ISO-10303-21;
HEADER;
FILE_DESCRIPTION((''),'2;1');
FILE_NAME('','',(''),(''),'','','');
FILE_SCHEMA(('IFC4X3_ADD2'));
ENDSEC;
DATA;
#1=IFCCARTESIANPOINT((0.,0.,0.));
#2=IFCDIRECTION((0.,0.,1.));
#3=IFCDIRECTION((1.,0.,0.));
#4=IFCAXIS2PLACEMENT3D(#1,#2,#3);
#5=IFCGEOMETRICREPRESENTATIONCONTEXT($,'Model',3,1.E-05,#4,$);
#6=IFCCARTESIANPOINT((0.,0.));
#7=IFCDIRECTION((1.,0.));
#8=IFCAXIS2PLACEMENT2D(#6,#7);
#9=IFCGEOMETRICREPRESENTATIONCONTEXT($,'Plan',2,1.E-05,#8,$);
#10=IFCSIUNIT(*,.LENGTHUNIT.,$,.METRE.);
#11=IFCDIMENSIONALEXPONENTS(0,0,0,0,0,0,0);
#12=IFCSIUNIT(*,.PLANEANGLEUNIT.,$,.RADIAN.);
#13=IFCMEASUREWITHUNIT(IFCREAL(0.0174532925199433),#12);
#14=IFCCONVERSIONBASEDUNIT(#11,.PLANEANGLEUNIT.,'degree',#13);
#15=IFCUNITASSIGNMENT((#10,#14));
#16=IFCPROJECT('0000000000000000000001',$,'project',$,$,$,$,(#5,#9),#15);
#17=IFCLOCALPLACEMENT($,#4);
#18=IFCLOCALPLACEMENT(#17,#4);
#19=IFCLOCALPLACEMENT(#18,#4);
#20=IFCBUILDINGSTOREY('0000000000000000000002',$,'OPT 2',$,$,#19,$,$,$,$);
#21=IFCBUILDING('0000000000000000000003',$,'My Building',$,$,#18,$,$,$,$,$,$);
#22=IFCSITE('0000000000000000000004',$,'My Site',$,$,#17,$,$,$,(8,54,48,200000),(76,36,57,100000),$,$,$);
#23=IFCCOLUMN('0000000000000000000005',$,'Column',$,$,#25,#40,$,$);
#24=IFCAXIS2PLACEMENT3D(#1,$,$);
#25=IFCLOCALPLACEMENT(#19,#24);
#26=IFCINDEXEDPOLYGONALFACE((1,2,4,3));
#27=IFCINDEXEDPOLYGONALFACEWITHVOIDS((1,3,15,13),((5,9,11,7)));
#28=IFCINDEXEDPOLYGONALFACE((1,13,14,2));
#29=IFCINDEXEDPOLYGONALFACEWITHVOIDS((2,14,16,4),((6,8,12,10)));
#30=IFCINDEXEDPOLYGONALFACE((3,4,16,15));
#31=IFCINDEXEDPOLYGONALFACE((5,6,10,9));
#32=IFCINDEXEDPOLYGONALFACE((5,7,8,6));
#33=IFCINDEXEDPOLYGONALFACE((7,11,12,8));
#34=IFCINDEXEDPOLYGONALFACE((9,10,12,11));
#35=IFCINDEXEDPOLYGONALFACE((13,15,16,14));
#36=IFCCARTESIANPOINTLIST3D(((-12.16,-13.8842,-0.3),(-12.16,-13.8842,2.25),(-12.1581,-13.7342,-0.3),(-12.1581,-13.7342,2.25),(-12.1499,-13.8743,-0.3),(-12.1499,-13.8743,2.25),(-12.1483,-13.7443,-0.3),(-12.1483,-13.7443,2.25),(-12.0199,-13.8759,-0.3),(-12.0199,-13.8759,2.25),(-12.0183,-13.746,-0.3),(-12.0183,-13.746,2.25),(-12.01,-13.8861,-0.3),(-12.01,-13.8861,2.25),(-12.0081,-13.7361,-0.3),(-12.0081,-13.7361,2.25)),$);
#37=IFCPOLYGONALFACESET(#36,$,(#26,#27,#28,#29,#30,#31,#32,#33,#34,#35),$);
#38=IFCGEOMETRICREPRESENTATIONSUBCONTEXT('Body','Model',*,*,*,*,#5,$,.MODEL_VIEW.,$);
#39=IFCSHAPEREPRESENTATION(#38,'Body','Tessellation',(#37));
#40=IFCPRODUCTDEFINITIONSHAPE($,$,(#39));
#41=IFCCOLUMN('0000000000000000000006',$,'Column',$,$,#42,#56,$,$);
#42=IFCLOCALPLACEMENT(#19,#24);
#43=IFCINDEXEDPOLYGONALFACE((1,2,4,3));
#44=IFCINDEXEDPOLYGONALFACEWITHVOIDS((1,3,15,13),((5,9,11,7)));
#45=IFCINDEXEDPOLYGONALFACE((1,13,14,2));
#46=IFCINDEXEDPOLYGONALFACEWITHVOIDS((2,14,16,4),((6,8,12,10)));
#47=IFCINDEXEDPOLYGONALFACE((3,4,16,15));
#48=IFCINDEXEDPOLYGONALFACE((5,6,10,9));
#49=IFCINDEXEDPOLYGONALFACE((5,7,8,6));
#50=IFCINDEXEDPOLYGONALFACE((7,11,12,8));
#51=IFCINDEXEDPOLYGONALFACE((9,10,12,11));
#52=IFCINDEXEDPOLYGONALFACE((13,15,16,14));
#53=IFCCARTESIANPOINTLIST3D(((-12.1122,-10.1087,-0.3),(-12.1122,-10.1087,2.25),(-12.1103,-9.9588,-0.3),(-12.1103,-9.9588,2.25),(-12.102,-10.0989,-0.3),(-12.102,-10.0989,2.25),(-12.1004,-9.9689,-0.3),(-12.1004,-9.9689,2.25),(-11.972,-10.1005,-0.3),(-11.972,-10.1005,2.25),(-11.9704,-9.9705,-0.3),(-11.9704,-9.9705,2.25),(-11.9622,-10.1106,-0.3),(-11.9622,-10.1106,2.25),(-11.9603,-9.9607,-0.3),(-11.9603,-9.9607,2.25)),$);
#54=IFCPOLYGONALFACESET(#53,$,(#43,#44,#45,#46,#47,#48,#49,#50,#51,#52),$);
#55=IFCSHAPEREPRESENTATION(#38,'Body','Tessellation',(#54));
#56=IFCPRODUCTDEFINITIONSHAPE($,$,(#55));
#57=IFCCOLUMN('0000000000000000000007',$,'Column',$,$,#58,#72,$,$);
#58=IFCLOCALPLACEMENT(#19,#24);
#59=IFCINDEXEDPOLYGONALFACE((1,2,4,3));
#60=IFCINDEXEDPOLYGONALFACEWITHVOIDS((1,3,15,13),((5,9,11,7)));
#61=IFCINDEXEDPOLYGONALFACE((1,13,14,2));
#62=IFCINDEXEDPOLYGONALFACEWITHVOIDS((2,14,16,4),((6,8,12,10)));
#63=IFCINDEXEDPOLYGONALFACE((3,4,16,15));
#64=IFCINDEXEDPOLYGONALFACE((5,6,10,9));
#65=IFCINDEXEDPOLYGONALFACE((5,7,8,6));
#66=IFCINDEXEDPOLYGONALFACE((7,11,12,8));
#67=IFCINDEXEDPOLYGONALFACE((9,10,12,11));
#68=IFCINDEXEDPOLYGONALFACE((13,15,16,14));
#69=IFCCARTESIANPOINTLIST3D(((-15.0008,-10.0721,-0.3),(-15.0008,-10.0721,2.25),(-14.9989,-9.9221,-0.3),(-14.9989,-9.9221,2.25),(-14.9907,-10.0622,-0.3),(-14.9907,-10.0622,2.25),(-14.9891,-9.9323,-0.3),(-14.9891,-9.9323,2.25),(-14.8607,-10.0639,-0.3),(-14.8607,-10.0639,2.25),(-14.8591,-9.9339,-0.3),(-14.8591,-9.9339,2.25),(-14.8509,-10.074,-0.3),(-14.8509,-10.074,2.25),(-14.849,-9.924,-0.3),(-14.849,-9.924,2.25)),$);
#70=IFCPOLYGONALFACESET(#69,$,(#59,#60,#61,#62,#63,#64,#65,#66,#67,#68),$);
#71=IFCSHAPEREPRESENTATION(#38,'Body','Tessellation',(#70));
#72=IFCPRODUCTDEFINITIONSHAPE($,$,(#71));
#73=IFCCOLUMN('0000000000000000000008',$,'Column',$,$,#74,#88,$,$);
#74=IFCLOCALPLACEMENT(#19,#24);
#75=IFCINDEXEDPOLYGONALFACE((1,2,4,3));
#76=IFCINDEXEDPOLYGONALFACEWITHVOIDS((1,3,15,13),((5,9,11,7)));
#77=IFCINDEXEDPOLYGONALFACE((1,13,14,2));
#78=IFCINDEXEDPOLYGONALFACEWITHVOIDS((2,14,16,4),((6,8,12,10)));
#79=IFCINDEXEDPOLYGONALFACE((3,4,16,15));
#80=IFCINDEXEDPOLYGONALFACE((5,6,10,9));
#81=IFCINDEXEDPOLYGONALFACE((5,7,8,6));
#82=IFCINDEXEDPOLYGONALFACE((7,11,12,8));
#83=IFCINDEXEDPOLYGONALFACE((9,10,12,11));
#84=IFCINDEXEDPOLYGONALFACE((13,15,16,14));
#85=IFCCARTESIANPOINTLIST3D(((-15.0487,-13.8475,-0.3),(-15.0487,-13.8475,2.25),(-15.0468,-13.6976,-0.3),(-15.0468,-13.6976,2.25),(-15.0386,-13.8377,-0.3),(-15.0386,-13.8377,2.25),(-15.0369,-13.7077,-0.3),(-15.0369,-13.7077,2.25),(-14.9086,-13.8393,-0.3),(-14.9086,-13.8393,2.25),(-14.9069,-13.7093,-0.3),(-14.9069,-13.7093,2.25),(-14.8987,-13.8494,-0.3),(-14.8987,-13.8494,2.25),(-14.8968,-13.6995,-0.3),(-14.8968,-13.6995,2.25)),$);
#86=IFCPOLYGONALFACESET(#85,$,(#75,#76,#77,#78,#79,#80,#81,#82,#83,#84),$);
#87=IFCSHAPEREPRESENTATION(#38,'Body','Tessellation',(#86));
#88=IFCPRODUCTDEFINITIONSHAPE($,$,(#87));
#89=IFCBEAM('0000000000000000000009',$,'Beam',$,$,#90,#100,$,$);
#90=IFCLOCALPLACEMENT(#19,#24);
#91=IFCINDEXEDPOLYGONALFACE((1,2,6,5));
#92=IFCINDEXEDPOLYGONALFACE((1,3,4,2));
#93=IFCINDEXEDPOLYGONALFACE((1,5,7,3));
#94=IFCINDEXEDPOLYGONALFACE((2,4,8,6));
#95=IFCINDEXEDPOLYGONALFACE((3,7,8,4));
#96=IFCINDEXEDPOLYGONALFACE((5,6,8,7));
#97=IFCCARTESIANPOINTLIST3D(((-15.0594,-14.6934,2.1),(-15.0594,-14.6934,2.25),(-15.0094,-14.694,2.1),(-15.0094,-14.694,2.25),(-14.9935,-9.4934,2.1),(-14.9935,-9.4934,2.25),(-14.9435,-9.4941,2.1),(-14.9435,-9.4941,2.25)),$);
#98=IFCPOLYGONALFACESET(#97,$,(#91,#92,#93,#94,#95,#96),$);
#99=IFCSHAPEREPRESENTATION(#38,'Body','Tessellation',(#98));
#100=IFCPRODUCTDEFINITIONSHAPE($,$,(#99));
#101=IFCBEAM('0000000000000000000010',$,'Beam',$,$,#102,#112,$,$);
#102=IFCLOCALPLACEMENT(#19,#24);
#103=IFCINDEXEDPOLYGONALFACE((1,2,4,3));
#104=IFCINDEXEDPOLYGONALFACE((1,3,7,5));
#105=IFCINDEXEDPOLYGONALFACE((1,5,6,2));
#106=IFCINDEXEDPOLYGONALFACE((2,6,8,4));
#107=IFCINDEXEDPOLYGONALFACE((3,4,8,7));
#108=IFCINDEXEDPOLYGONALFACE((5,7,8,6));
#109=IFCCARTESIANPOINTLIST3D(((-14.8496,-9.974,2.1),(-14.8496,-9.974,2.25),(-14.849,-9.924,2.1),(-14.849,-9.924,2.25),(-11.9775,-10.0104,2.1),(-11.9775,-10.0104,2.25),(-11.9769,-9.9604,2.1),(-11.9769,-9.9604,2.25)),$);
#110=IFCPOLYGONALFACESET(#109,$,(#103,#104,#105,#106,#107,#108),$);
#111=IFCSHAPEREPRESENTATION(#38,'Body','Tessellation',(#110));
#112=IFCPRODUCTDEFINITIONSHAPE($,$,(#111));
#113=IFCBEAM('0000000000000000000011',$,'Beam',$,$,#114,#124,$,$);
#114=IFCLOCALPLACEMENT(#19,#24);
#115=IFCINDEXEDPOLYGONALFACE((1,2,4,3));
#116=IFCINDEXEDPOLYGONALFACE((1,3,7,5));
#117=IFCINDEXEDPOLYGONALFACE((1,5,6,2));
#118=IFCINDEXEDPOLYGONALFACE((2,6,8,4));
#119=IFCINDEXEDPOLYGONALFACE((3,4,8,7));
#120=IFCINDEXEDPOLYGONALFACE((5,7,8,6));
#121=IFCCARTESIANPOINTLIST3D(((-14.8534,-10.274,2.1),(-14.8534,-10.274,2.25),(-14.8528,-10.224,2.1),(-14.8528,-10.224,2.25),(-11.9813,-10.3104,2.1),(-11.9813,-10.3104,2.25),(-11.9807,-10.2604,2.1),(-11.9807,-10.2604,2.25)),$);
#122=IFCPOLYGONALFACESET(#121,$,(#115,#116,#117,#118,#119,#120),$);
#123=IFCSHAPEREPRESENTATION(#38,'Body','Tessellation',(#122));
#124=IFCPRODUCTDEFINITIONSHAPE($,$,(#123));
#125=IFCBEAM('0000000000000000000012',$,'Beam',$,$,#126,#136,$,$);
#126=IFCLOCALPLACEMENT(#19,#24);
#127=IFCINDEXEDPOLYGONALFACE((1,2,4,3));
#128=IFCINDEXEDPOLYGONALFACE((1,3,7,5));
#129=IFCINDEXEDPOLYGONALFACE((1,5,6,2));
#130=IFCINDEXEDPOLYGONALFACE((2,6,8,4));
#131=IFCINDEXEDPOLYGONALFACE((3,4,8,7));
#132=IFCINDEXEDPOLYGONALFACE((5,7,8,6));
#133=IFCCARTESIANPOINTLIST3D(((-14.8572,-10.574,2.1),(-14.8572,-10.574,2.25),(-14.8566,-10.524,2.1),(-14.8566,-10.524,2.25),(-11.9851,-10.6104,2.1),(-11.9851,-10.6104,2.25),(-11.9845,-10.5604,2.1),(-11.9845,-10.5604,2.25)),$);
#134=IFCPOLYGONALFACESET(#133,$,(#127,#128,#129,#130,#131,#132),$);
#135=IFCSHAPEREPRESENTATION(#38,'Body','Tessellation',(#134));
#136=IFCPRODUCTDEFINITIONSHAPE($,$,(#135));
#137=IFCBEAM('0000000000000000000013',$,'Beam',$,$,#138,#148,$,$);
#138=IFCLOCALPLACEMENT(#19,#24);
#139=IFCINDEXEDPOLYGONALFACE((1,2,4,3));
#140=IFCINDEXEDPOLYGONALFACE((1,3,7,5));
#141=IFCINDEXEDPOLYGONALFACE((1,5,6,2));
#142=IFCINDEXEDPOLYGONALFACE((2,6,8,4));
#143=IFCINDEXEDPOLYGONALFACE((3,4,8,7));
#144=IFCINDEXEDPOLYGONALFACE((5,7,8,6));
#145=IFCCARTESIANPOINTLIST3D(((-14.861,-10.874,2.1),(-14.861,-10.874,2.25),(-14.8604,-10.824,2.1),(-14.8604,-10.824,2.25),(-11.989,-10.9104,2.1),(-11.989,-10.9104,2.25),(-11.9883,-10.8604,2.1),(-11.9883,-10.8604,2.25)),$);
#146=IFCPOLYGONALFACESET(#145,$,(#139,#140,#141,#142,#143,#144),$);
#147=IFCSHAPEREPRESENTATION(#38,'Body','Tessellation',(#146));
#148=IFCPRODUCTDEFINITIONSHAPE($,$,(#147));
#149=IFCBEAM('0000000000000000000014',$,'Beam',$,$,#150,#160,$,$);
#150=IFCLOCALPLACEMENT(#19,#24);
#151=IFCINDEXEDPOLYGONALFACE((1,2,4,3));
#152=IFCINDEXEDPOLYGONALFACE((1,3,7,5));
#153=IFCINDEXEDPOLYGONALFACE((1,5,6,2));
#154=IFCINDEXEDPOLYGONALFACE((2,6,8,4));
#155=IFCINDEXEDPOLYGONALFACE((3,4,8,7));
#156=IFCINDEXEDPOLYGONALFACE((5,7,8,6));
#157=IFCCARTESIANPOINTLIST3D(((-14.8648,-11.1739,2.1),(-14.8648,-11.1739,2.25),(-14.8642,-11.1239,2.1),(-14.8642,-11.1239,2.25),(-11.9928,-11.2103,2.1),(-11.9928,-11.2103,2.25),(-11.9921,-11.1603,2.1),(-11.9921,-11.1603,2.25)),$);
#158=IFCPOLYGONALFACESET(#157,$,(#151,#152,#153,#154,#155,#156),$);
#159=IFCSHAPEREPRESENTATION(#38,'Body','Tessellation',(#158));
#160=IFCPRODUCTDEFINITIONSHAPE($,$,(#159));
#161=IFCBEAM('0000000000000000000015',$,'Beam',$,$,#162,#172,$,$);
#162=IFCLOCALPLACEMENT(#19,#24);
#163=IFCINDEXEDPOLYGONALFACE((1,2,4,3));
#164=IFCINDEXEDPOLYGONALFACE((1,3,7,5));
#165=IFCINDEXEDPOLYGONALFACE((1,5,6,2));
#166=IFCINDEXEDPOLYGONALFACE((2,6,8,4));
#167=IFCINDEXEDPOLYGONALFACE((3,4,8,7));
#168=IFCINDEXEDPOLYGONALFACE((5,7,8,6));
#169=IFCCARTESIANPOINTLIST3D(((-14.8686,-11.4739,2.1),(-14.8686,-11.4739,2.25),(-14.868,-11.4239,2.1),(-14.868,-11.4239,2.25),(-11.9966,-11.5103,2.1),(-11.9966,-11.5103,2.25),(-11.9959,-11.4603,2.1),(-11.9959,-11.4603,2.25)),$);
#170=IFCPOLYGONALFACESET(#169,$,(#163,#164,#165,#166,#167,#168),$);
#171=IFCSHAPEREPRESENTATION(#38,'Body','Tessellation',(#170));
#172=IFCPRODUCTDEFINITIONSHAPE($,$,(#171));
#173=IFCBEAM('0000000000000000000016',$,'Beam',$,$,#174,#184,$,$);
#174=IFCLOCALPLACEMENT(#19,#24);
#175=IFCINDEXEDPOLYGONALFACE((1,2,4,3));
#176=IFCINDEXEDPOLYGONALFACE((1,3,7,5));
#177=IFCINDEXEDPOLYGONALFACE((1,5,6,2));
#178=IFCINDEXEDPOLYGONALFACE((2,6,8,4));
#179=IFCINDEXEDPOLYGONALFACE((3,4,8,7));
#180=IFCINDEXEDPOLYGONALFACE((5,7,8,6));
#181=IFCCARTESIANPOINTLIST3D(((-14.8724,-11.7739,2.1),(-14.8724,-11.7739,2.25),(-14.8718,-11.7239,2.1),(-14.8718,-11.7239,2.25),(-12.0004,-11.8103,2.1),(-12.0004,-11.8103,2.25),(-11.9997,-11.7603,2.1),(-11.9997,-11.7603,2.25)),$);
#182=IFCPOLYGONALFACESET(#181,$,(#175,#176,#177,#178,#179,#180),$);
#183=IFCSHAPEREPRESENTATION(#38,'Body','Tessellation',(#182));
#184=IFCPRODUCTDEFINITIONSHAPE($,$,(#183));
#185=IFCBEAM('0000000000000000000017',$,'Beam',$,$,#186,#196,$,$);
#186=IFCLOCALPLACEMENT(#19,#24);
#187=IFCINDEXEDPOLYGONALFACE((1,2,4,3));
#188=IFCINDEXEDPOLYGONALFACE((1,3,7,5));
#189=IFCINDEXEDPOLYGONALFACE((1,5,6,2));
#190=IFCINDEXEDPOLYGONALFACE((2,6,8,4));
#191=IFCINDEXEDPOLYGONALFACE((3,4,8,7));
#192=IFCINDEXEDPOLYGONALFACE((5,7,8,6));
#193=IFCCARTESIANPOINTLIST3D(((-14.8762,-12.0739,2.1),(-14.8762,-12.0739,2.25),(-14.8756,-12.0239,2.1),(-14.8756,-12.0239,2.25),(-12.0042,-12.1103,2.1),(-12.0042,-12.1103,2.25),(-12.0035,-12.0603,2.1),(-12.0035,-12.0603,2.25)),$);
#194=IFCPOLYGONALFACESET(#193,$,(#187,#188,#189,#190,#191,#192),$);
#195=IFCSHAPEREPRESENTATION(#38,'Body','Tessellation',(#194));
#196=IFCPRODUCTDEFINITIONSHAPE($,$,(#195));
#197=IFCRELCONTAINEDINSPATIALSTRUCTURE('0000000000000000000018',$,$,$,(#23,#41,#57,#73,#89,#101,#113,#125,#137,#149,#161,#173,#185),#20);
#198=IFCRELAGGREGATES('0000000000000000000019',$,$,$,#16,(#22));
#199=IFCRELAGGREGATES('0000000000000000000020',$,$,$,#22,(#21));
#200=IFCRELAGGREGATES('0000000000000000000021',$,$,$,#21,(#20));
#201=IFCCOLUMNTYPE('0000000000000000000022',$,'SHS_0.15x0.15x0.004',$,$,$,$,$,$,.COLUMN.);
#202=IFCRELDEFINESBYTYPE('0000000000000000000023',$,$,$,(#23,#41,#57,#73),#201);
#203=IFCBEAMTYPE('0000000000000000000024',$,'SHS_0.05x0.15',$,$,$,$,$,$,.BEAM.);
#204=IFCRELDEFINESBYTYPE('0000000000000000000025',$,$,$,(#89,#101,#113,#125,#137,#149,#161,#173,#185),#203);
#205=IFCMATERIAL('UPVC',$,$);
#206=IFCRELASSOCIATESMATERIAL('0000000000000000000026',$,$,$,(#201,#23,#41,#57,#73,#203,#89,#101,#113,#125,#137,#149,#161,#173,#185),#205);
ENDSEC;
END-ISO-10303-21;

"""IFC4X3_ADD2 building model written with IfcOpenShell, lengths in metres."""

from ifc_helpers import new_model, entity, si_unit, converted_unit, frame, origin_with_axes, origin_2d_with_axis, place, context, subcontext, project, spatial, rectangle, hollow_rectangle, extrude, material, material_profile, profile_set, profile_usage, type_object, element, save


model = new_model("IFC4X3_ADD2")

# Units and contexts
model_context = context("Model", 3, precision=1e-05, world=origin_with_axes())
plan_context = context("Plan", 2, precision=1e-05, world=origin_2d_with_axis())
body_context = subcontext(model_context, "Body", "Model", "MODEL_VIEW")
ifc_project = project(units=[si_unit("LENGTHUNIT", "METRE"), converted_unit("PLANEANGLEUNIT", "degree", entity("IfcReal", 0.0174532925199433), si_unit("PLANEANGLEUNIT", "RADIAN"), dimensions=[0, 0, 0, 0, 0, 0, 0])], contexts=[model_context, plan_context])

# Site, building, storey
site_placement = place(None, origin_with_axes())
site = spatial("IfcSite", under=ifc_project, at=site_placement, Name="My Site", RefLatitude=(8, 54, 48, 200000), RefLongitude=(76, 36, 57, 100000))
building_placement = place(site_placement, origin_with_axes())
building = spatial("IfcBuilding", under=site, at=building_placement, Name="My Building")
storey_placement = place(building_placement, origin_with_axes())
storey = spatial("IfcBuildingStorey", under=building, at=storey_placement, Name="OPT 2")

# Columns
ifc_material_1 = material(Name="UPVC")
ifc_material_profile_1 = material_profile(ifc_material_1, hollow_rectangle(XDim=0.15, YDim=0.15, WallThickness=0.01))
ifc_profile_set_1 = profile_set([ifc_material_profile_1])
ifc_profile_usage_1 = profile_usage(ifc_profile_set_1, cardinal=5)
column_type = type_object("IfcColumnType", Name="SHS_0.15x0.15x0.004", PredefinedType="COLUMN", material=ifc_profile_set_1)
column_1_placement = place(storey_placement, frame((-12.0841, -13.8101, -0.3), z_axis=(0.0, 0.0, 1.0), x_axis=(0.99992, -0.012678, 0.0)))
element("IfcColumn", 1, at=column_1_placement, inside=storey, type_object=column_type, material=ifc_profile_usage_1, Name="Column", context=body_context, shape_type="SweptSolid", body=[
    extrude(hollow_rectangle(XDim=0.15, YDim=0.15, WallThickness=0.01), origin_with_axes(), (0.0, 0.0, 1.0), 2.55),
])
ifc_profile_usage_2 = profile_usage(ifc_profile_set_1, cardinal=5)
column_2_placement = place(storey_placement, frame((-12.0362, -10.0347, -0.3), z_axis=(0.0, 0.0, 1.0), x_axis=(0.99992, -0.012678, 0.0)))
element("IfcColumn", 2, at=column_2_placement, inside=storey, type_object=column_type, material=ifc_profile_usage_2, Name="Column", context=body_context, shape_type="SweptSolid", body=[
    extrude(hollow_rectangle(XDim=0.15, YDim=0.15, WallThickness=0.01), origin_with_axes(), (0.0, 0.0, 1.0), 2.55),
])
ifc_profile_usage_3 = profile_usage(ifc_profile_set_1, cardinal=5)
column_3_placement = place(storey_placement, frame((-14.9249, -9.9981, -0.3), z_axis=(0.0, 0.0, 1.0), x_axis=(0.99992, -0.012678, 0.0)))
element("IfcColumn", 3, at=column_3_placement, inside=storey, type_object=column_type, material=ifc_profile_usage_3, Name="Column", context=body_context, shape_type="SweptSolid", body=[
    extrude(hollow_rectangle(XDim=0.15, YDim=0.15, WallThickness=0.01), origin_with_axes(), (0.0, 0.0, 1.0), 2.55),
])
ifc_profile_usage_4 = profile_usage(ifc_profile_set_1, cardinal=5)
column_4_placement = place(storey_placement, frame((-14.9728, -13.7735, -0.3), z_axis=(0.0, 0.0, 1.0), x_axis=(0.99992, -0.012678, 0.0)))
element("IfcColumn", 4, at=column_4_placement, inside=storey, type_object=column_type, material=ifc_profile_usage_4, Name="Column", context=body_context, shape_type="SweptSolid", body=[
    extrude(hollow_rectangle(XDim=0.15, YDim=0.15, WallThickness=0.01), origin_with_axes(), (0.0, 0.0, 1.0), 2.55),
])

# Beams
ifc_material_profile_2 = material_profile(ifc_material_1, rectangle(XDim=0.05, YDim=0.15))
ifc_profile_set_2 = profile_set([ifc_material_profile_2])
ifc_profile_usage_5 = profile_usage(ifc_profile_set_2, cardinal=5)
beam_type = type_object("IfcBeamType", Name="SHS_0.05x0.15", PredefinedType="BEAM", material=ifc_profile_set_2)
beam_1_placement = place(storey_placement, frame((-15.0344, -14.6937, 2.175), z_axis=(0.012677, 0.99992, 0.0), x_axis=(-0.99992, 0.012677, 0.0)))
element("IfcBeam", 5, at=beam_1_placement, inside=storey, type_object=beam_type, material=ifc_profile_usage_5, Name="Beam", context=body_context, shape_type="SweptSolid", body=[
    extrude(rectangle(XDim=0.05, YDim=0.15), origin_with_axes(), (0.0, 0.0, 1.0), 5.2004),
])
ifc_profile_usage_6 = profile_usage(ifc_profile_set_2, cardinal=5)
beam_2_placement = place(storey_placement, frame((-11.9772, -9.9854, 2.175), z_axis=(-0.99992, 0.012677, 0.000001), x_axis=(-0.012677, -0.99992, 0.0)))
element("IfcBeam", 6, at=beam_2_placement, inside=storey, type_object=beam_type, material=ifc_profile_usage_6, Name="Beam", context=body_context, shape_type="SweptSolid", body=[
    extrude(rectangle(XDim=0.05, YDim=0.15), origin_with_axes(), (0.0, 0.0, 1.0), 2.8723),
])
ifc_profile_usage_7 = profile_usage(ifc_profile_set_2, cardinal=5)
beam_3_placement = place(storey_placement, frame((-11.981, -10.2854, 2.175), z_axis=(-0.99992, 0.012677, 0.000001), x_axis=(-0.012677, -0.99992, 0.0)))
element("IfcBeam", 7, at=beam_3_placement, inside=storey, type_object=beam_type, material=ifc_profile_usage_7, Name="Beam", context=body_context, shape_type="SweptSolid", body=[
    extrude(rectangle(XDim=0.05, YDim=0.15), origin_with_axes(), (0.0, 0.0, 1.0), 2.8723),
])
ifc_profile_usage_8 = profile_usage(ifc_profile_set_2, cardinal=5)
beam_4_placement = place(storey_placement, frame((-11.9848, -10.5854, 2.175), z_axis=(-0.99992, 0.012677, 0.000001), x_axis=(-0.012677, -0.99992, 0.0)))
element("IfcBeam", 8, at=beam_4_placement, inside=storey, type_object=beam_type, material=ifc_profile_usage_8, Name="Beam", context=body_context, shape_type="SweptSolid", body=[
    extrude(rectangle(XDim=0.05, YDim=0.15), origin_with_axes(), (0.0, 0.0, 1.0), 2.8723),
])
ifc_profile_usage_9 = profile_usage(ifc_profile_set_2, cardinal=5)
beam_5_placement = place(storey_placement, frame((-11.9886, -10.8854, 2.175), z_axis=(-0.99992, 0.012677, 0.000001), x_axis=(-0.012677, -0.99992, 0.0)))
element("IfcBeam", 9, at=beam_5_placement, inside=storey, type_object=beam_type, material=ifc_profile_usage_9, Name="Beam", context=body_context, shape_type="SweptSolid", body=[
    extrude(rectangle(XDim=0.05, YDim=0.15), origin_with_axes(), (0.0, 0.0, 1.0), 2.8723),
])
ifc_profile_usage_10 = profile_usage(ifc_profile_set_2, cardinal=5)
beam_6_placement = place(storey_placement, frame((-11.9924, -11.1853, 2.175), z_axis=(-0.99992, 0.012677, 0.000001), x_axis=(-0.012677, -0.99992, 0.0)))
element("IfcBeam", 10, at=beam_6_placement, inside=storey, type_object=beam_type, material=ifc_profile_usage_10, Name="Beam", context=body_context, shape_type="SweptSolid", body=[
    extrude(rectangle(XDim=0.05, YDim=0.15), origin_with_axes(), (0.0, 0.0, 1.0), 2.8723),
])
ifc_profile_usage_11 = profile_usage(ifc_profile_set_2, cardinal=5)
beam_7_placement = place(storey_placement, frame((-11.9962, -11.4853, 2.175), z_axis=(-0.99992, 0.012677, 0.000001), x_axis=(-0.012677, -0.99992, 0.0)))
element("IfcBeam", 11, at=beam_7_placement, inside=storey, type_object=beam_type, material=ifc_profile_usage_11, Name="Beam", context=body_context, shape_type="SweptSolid", body=[
    extrude(rectangle(XDim=0.05, YDim=0.15), origin_with_axes(), (0.0, 0.0, 1.0), 2.8723),
])
ifc_profile_usage_12 = profile_usage(ifc_profile_set_2, cardinal=5)
beam_8_placement = place(storey_placement, frame((-12.0, -11.7853, 2.175), z_axis=(-0.99992, 0.012677, 0.000001), x_axis=(-0.012677, -0.99992, 0.0)))
element("IfcBeam", 12, at=beam_8_placement, inside=storey, type_object=beam_type, material=ifc_profile_usage_12, Name="Beam", context=body_context, shape_type="SweptSolid", body=[
    extrude(rectangle(XDim=0.05, YDim=0.15), origin_with_axes(), (0.0, 0.0, 1.0), 2.8723),
])
ifc_profile_usage_13 = profile_usage(ifc_profile_set_2, cardinal=5)
beam_9_placement = place(storey_placement, frame((-12.0038, -12.0853, 2.175), z_axis=(-0.99992, 0.012677, 0.000001), x_axis=(-0.012677, -0.99992, 0.0)))
element("IfcBeam", 13, at=beam_9_placement, inside=storey, type_object=beam_type, material=ifc_profile_usage_13, Name="Beam", context=body_context, shape_type="SweptSolid", body=[
    extrude(rectangle(XDim=0.05, YDim=0.15), origin_with_axes(), (0.0, 0.0, 1.0), 2.8723),
])

save(model, "model.ifc")
